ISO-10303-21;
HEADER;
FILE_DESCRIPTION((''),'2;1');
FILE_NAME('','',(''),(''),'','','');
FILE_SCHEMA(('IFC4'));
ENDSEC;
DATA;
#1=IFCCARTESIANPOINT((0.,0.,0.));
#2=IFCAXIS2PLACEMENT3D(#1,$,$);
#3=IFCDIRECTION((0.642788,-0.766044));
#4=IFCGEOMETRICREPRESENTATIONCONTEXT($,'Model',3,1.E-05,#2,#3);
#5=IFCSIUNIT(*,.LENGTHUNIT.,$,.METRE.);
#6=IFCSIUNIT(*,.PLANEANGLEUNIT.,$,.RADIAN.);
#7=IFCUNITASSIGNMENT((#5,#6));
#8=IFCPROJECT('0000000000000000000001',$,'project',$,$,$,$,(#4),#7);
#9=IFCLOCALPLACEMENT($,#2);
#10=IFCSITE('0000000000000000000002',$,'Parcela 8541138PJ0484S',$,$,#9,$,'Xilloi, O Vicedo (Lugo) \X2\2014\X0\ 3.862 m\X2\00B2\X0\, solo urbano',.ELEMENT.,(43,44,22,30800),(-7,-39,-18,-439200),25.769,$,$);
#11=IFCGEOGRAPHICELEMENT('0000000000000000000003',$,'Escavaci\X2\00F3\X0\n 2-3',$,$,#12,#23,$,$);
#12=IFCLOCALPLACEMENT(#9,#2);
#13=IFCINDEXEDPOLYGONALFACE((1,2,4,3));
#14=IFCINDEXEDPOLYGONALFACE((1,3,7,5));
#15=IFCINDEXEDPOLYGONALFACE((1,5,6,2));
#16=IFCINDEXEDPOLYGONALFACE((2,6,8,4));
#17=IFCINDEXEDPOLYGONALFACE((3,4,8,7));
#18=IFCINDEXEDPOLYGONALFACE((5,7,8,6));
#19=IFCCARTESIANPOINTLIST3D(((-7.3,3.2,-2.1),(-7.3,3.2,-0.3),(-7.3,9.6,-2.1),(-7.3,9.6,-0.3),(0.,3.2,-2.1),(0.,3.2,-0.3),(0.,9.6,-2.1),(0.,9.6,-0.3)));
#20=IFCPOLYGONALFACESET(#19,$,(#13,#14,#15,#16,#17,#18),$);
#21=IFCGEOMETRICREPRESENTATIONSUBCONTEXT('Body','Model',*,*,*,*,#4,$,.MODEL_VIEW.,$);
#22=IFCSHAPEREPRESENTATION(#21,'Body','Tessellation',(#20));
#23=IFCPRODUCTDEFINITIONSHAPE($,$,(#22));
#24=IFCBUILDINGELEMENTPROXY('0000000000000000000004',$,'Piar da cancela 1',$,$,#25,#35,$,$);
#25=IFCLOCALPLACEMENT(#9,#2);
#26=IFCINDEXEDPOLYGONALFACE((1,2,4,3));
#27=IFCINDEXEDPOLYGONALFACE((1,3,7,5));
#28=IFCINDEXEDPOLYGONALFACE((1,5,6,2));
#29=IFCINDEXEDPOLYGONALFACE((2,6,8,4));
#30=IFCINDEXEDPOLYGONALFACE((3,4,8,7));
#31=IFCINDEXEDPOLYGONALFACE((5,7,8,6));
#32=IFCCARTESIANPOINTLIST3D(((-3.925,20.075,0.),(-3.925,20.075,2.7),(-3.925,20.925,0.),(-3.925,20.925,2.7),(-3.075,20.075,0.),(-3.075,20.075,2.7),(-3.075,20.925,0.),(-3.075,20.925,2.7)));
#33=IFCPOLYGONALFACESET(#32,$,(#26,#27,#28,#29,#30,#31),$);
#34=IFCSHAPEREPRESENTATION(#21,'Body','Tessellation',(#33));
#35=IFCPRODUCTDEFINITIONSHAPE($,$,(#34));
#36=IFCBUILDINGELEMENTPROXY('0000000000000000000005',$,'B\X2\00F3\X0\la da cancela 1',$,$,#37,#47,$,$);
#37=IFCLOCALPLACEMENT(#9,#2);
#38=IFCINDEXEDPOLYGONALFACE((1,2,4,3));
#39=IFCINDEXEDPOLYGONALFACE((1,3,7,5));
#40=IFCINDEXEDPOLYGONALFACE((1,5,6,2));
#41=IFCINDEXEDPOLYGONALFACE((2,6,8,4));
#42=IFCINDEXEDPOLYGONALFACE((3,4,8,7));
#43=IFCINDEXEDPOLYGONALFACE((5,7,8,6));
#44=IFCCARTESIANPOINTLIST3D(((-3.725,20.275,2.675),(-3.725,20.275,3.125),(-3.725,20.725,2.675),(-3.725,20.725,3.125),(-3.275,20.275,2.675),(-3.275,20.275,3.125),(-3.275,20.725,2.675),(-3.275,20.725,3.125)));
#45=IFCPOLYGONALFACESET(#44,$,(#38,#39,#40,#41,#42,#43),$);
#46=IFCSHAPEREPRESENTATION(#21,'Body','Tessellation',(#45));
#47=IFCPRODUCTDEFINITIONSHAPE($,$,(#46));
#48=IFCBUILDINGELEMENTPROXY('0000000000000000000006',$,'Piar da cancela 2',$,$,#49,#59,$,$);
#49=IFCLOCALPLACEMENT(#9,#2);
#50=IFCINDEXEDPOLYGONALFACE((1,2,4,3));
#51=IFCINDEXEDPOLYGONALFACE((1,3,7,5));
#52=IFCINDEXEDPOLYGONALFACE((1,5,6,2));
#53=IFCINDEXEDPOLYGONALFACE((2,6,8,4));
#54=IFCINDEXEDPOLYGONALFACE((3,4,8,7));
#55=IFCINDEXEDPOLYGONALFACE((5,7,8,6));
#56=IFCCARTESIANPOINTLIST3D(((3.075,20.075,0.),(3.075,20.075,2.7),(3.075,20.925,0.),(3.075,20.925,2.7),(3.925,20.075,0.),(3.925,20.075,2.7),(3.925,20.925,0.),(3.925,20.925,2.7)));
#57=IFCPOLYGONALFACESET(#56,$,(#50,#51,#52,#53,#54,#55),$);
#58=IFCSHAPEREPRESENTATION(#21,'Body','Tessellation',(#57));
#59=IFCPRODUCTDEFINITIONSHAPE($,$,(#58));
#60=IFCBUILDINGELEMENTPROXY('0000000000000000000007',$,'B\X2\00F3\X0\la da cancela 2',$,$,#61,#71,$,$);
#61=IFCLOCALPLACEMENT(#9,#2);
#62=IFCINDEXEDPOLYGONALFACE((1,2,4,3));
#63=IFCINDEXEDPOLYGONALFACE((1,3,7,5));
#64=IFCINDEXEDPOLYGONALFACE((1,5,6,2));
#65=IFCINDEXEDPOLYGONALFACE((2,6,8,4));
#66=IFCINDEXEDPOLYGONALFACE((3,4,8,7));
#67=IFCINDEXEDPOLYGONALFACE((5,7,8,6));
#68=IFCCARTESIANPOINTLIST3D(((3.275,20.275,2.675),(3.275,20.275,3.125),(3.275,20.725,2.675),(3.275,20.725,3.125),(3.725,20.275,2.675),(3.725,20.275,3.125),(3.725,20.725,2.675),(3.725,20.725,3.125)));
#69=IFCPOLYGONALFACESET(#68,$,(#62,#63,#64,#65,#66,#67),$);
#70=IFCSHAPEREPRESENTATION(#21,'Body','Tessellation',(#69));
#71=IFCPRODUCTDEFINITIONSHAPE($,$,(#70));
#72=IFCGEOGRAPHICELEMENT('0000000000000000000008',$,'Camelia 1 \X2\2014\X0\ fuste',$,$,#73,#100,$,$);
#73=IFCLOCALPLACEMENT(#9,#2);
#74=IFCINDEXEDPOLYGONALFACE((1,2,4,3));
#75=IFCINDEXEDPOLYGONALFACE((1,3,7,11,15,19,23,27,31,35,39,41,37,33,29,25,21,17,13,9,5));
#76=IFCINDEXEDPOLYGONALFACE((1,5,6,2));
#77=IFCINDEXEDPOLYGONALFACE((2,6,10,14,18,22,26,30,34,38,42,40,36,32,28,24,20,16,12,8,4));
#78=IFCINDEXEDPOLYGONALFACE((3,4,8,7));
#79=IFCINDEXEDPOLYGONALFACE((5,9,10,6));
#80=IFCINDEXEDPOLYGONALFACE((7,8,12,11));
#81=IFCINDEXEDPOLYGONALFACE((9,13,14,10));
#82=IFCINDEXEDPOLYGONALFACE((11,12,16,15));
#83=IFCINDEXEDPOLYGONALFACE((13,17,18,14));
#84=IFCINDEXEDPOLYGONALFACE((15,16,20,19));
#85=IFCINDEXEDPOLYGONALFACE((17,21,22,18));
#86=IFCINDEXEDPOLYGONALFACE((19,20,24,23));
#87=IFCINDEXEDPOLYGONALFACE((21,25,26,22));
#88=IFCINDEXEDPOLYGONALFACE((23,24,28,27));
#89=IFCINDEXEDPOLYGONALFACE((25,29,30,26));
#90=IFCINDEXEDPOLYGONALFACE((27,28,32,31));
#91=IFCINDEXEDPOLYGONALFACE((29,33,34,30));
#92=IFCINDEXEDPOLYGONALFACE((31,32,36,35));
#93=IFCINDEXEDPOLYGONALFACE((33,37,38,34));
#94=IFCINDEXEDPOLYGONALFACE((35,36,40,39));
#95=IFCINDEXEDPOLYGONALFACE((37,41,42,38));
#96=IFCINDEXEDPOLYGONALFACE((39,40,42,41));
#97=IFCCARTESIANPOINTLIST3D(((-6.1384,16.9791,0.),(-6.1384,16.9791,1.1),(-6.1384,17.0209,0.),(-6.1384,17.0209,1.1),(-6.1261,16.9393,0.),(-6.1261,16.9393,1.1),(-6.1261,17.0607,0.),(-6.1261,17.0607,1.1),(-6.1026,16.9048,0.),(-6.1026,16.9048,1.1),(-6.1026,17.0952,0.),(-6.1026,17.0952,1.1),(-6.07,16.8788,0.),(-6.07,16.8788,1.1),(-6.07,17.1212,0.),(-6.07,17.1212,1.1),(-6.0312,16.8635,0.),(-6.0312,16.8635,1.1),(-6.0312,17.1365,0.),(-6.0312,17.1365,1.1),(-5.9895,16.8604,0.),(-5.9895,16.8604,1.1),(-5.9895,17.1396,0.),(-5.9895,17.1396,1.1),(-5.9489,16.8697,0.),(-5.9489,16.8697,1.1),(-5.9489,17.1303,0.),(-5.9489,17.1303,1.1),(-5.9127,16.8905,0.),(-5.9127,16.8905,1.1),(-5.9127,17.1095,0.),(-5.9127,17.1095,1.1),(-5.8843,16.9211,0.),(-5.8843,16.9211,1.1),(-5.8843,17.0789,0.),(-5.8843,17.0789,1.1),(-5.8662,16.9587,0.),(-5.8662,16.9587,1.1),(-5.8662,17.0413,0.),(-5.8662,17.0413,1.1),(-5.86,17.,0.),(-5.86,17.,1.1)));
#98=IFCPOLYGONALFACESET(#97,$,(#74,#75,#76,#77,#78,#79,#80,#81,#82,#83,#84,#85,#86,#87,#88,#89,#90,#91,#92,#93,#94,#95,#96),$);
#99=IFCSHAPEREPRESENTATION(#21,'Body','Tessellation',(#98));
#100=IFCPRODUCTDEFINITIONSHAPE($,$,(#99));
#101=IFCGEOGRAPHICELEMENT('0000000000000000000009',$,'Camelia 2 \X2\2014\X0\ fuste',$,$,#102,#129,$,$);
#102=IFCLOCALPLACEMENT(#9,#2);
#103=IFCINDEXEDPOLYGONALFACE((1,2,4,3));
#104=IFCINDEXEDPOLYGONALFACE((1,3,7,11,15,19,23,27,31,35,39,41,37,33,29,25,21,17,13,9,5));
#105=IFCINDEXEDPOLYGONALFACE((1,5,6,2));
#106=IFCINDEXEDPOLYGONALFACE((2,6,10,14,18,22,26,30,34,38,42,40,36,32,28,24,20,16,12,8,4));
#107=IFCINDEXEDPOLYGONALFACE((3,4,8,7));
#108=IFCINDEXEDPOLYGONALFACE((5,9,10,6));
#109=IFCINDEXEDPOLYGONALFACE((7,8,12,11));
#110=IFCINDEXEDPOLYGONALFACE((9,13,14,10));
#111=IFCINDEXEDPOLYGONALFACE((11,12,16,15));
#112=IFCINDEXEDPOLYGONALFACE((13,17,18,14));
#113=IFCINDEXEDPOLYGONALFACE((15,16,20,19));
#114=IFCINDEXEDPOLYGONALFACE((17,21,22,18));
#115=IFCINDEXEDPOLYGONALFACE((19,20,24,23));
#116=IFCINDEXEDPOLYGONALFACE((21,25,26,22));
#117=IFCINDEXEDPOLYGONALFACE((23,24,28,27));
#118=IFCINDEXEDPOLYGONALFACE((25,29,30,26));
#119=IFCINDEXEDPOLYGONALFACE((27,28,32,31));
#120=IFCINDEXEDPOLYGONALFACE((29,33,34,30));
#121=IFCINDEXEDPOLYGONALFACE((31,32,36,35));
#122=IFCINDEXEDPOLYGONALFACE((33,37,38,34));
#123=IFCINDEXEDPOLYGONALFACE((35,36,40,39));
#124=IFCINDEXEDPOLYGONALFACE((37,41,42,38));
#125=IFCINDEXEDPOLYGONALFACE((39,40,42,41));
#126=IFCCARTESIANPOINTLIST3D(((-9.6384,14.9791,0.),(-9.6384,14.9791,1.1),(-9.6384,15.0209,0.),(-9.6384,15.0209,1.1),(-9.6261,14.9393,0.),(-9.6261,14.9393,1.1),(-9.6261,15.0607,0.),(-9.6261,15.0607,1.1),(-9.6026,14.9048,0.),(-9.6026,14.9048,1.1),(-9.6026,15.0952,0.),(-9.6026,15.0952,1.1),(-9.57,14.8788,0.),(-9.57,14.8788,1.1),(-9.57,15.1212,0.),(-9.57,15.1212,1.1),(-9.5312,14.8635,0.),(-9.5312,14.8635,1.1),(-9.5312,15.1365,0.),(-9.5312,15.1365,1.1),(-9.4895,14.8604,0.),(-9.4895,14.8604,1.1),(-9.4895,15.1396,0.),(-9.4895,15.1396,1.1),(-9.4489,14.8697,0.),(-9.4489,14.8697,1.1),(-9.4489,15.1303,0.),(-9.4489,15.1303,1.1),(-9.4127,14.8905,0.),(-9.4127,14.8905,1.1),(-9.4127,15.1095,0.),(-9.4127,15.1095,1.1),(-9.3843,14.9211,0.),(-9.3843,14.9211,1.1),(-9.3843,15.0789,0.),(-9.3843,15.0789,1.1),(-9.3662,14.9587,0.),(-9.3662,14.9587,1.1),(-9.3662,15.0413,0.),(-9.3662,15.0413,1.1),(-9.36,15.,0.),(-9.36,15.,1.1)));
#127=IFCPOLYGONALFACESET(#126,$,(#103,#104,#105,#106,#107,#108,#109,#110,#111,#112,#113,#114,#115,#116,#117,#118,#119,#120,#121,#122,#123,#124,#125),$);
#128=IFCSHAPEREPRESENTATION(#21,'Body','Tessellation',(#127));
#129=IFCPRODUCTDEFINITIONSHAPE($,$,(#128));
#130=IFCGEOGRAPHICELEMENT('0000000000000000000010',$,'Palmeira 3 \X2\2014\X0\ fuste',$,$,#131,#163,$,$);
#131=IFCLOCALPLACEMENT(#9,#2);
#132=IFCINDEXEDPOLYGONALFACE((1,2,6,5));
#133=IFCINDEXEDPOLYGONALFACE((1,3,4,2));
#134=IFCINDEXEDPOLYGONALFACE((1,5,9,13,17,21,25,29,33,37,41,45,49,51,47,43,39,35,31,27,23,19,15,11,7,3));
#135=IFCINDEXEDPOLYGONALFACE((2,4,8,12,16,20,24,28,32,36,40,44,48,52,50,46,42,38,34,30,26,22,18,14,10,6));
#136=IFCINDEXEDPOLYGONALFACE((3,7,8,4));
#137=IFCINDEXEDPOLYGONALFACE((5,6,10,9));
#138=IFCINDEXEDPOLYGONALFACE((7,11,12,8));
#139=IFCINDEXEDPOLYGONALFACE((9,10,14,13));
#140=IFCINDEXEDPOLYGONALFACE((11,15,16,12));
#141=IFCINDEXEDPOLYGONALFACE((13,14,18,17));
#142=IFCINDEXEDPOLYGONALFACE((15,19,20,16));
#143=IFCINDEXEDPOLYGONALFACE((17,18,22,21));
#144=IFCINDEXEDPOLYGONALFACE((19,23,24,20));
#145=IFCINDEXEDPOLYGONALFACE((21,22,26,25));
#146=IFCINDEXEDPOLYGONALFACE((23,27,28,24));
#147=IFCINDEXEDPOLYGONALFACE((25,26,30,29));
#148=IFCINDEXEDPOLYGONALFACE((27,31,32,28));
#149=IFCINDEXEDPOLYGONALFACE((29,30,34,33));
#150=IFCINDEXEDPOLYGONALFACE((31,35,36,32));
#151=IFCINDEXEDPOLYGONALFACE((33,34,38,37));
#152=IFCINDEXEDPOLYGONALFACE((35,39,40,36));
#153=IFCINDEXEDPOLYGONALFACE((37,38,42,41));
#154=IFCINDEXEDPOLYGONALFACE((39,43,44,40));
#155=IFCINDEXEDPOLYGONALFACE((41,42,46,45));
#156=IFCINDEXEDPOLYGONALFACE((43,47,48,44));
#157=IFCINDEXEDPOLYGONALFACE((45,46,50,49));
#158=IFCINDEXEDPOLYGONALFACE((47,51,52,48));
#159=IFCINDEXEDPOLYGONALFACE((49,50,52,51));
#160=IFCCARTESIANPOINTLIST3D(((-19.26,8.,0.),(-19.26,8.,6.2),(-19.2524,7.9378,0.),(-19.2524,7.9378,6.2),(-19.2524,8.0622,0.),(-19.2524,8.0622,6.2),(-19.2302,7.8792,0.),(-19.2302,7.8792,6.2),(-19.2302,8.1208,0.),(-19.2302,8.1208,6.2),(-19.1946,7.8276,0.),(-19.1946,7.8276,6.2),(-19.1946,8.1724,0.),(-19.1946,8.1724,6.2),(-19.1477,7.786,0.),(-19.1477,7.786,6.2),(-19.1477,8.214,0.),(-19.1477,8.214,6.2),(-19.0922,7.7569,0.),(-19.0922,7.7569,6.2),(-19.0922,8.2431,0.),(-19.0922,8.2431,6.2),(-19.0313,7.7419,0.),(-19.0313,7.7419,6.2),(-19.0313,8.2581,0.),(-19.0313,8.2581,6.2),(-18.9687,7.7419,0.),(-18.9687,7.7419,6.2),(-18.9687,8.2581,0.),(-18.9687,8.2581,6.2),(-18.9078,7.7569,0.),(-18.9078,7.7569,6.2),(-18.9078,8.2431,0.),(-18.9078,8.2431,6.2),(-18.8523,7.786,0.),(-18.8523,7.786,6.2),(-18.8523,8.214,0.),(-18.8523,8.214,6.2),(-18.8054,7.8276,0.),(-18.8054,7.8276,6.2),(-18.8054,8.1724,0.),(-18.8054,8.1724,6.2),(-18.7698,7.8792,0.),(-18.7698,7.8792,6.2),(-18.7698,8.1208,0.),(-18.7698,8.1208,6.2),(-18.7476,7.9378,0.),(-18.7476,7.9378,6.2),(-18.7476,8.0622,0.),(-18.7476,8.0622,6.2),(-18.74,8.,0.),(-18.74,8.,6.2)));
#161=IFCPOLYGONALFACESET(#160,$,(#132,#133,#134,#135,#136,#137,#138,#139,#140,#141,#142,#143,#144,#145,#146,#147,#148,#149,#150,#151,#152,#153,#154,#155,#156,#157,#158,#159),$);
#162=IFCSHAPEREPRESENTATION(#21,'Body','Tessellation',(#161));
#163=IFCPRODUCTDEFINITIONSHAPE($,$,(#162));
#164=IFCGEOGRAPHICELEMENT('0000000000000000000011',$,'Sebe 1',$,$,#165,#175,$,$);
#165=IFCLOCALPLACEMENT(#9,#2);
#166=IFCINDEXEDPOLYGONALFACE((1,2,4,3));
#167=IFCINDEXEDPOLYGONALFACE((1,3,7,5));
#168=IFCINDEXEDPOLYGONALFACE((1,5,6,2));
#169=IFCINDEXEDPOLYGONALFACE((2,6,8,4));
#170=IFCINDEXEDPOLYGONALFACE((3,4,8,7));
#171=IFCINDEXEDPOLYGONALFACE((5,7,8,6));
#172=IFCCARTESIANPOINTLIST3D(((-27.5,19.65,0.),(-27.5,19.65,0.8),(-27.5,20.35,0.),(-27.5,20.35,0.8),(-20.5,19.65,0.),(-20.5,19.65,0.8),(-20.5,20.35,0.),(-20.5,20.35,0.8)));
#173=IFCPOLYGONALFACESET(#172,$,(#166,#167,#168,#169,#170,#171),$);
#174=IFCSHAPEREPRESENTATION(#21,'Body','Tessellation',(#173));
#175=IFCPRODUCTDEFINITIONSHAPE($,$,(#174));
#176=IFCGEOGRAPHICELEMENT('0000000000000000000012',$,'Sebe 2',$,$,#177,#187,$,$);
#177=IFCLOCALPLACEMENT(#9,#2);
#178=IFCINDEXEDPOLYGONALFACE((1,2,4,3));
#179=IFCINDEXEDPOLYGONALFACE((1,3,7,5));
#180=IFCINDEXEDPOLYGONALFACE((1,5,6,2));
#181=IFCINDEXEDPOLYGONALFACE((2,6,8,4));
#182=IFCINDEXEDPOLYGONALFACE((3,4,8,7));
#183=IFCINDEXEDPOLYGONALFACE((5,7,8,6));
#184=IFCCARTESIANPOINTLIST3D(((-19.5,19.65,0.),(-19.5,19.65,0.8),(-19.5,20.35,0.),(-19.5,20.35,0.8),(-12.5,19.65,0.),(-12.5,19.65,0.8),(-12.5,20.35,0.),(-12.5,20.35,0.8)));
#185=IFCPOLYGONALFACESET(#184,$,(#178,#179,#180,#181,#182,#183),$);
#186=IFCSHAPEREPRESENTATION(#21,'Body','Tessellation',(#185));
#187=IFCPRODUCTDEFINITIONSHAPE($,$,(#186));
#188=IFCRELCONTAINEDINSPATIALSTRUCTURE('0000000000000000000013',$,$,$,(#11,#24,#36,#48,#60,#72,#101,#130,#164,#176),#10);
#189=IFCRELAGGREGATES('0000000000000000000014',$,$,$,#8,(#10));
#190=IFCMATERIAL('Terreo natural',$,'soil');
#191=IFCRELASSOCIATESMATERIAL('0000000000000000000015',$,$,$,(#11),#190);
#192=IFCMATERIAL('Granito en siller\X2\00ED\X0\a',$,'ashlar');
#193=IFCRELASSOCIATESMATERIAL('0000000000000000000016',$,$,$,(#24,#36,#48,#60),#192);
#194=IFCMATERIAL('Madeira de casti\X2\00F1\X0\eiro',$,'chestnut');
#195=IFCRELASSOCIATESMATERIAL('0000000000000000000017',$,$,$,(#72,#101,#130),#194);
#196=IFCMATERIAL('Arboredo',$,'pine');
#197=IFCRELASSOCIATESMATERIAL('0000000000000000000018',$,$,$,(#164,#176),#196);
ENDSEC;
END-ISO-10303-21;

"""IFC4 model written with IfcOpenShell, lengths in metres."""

from ifc_helpers import new_model, si_unit, direction, frame, origin, origin_2d, place, context, subcontext, project, spatial, rectangle, circle, extrude, material, element, save


model = new_model("IFC4")

# Units and contexts
model_context = context("Model", 3, precision=1e-05, world=origin(), true_north=direction((0.642788, -0.766044)))
body_context = subcontext(model_context, "Body", "Model", "MODEL_VIEW")
ifc_project = project(units=[si_unit("LENGTHUNIT", "METRE"), si_unit("PLANEANGLEUNIT", "RADIAN")], contexts=[model_context])

# Site
site_placement = place(None, origin())
site = spatial("IfcSite", under=ifc_project, at=site_placement, Name="Parcela 8541138PJ0484S", LongName="Xilloi, O Vicedo (Lugo) — 3.862 m², solo urbano", CompositionType="ELEMENT", RefLatitude=(43, 44, 22, 30800), RefLongitude=(-7, -39, -18, -439200), RefElevation=25.769)

# Geographic element
ifc_material_1 = material(Name="Madeira de castiñeiro", Category="chestnut")
ifc_material_2 = material(Name="Terreo natural", Category="soil")
geographic_element_1_placement = place(site_placement, frame((-3.65, 6.4, -1.2)))
element("IfcGeographicElement", 1, at=geographic_element_1_placement, inside=site, material=ifc_material_2, Name="Escavación 2-3", context=body_context, shape_type="SweptSolid", body=[
    extrude(rectangle(XDim=7.3, YDim=6.4, at=origin_2d()), frame((0.0, 0.0, -0.9)), (0.0, 0.0, 1.0), 1.8),
])

# Building element proxies
ifc_material_3 = material(Name="Granito en sillería", Category="ashlar")
proxy_1_placement = place(site_placement, frame((-3.5, 20.5, 1.35)))
element("IfcBuildingElementProxy", 2, at=proxy_1_placement, inside=site, material=ifc_material_3, Name="Piar da cancela 1", context=body_context, shape_type="SweptSolid", body=[
    extrude(rectangle(XDim=0.85, YDim=0.85, at=origin_2d()), frame((0.0, 0.0, -1.35)), (0.0, 0.0, 1.0), 2.7),
])
proxy_2_placement = place(site_placement, frame((-3.5, 20.5, 2.9)))
element("IfcBuildingElementProxy", 3, at=proxy_2_placement, inside=site, material=ifc_material_3, Name="Bóla da cancela 1", context=body_context, shape_type="SweptSolid", body=[
    extrude(rectangle(XDim=0.45, YDim=0.45, at=origin_2d()), frame((0.0, 0.0, -0.225)), (0.0, 0.0, 1.0), 0.45),
])
proxy_3_placement = place(site_placement, frame((3.5, 20.5, 1.35)))
element("IfcBuildingElementProxy", 4, at=proxy_3_placement, inside=site, material=ifc_material_3, Name="Piar da cancela 2", context=body_context, shape_type="SweptSolid", body=[
    extrude(rectangle(XDim=0.85, YDim=0.85, at=origin_2d()), frame((0.0, 0.0, -1.35)), (0.0, 0.0, 1.0), 2.7),
])
proxy_4_placement = place(site_placement, frame((3.5, 20.5, 2.9)))
element("IfcBuildingElementProxy", 5, at=proxy_4_placement, inside=site, material=ifc_material_3, Name="Bóla da cancela 2", context=body_context, shape_type="SweptSolid", body=[
    extrude(rectangle(XDim=0.45, YDim=0.45, at=origin_2d()), frame((0.0, 0.0, -0.225)), (0.0, 0.0, 1.0), 0.45),
])

# Geographic elements
for number, where, name in (
    (6, (-6.0, 17.0, 0.55), "Camelia 1 — fuste"),
    (7, (-9.5, 15.0, 0.55), "Camelia 2 — fuste"),
):
    element("IfcGeographicElement", number, at=place(site_placement, frame(where)), inside=site, material=ifc_material_1, Name=name, context=body_context, shape_type="SweptSolid", body=[
        extrude(circle(Radius=0.14, at=origin_2d()), frame((0.0, 0.0, -0.55)), (0.0, 0.0, 1.0), 1.1),
    ])
geographic_element_2_placement = place(site_placement, frame((-19.0, 8.0, 3.1)))
element("IfcGeographicElement", 8, at=geographic_element_2_placement, inside=site, material=ifc_material_1, Name="Palmeira 3 — fuste", context=body_context, shape_type="SweptSolid", body=[
    extrude(circle(Radius=0.26, at=origin_2d()), frame((0.0, 0.0, -3.1)), (0.0, 0.0, 1.0), 6.2),
])
ifc_material_4 = material(Name="Arboredo", Category="pine")
for number, where, name in (
    (9, (-24.0, 20.0, 0.4), "Sebe 1"),
    (10, (-16.0, 20.0, 0.4), "Sebe 2"),
):
    element("IfcGeographicElement", number, at=place(site_placement, frame(where)), inside=site, material=ifc_material_4, Name=name, context=body_context, shape_type="SweptSolid", body=[
        extrude(rectangle(XDim=7.0, YDim=0.7, at=origin_2d()), frame((0.0, 0.0, -0.4)), (0.0, 0.0, 1.0), 0.8),
    ])

save(model, "model.ifc")
